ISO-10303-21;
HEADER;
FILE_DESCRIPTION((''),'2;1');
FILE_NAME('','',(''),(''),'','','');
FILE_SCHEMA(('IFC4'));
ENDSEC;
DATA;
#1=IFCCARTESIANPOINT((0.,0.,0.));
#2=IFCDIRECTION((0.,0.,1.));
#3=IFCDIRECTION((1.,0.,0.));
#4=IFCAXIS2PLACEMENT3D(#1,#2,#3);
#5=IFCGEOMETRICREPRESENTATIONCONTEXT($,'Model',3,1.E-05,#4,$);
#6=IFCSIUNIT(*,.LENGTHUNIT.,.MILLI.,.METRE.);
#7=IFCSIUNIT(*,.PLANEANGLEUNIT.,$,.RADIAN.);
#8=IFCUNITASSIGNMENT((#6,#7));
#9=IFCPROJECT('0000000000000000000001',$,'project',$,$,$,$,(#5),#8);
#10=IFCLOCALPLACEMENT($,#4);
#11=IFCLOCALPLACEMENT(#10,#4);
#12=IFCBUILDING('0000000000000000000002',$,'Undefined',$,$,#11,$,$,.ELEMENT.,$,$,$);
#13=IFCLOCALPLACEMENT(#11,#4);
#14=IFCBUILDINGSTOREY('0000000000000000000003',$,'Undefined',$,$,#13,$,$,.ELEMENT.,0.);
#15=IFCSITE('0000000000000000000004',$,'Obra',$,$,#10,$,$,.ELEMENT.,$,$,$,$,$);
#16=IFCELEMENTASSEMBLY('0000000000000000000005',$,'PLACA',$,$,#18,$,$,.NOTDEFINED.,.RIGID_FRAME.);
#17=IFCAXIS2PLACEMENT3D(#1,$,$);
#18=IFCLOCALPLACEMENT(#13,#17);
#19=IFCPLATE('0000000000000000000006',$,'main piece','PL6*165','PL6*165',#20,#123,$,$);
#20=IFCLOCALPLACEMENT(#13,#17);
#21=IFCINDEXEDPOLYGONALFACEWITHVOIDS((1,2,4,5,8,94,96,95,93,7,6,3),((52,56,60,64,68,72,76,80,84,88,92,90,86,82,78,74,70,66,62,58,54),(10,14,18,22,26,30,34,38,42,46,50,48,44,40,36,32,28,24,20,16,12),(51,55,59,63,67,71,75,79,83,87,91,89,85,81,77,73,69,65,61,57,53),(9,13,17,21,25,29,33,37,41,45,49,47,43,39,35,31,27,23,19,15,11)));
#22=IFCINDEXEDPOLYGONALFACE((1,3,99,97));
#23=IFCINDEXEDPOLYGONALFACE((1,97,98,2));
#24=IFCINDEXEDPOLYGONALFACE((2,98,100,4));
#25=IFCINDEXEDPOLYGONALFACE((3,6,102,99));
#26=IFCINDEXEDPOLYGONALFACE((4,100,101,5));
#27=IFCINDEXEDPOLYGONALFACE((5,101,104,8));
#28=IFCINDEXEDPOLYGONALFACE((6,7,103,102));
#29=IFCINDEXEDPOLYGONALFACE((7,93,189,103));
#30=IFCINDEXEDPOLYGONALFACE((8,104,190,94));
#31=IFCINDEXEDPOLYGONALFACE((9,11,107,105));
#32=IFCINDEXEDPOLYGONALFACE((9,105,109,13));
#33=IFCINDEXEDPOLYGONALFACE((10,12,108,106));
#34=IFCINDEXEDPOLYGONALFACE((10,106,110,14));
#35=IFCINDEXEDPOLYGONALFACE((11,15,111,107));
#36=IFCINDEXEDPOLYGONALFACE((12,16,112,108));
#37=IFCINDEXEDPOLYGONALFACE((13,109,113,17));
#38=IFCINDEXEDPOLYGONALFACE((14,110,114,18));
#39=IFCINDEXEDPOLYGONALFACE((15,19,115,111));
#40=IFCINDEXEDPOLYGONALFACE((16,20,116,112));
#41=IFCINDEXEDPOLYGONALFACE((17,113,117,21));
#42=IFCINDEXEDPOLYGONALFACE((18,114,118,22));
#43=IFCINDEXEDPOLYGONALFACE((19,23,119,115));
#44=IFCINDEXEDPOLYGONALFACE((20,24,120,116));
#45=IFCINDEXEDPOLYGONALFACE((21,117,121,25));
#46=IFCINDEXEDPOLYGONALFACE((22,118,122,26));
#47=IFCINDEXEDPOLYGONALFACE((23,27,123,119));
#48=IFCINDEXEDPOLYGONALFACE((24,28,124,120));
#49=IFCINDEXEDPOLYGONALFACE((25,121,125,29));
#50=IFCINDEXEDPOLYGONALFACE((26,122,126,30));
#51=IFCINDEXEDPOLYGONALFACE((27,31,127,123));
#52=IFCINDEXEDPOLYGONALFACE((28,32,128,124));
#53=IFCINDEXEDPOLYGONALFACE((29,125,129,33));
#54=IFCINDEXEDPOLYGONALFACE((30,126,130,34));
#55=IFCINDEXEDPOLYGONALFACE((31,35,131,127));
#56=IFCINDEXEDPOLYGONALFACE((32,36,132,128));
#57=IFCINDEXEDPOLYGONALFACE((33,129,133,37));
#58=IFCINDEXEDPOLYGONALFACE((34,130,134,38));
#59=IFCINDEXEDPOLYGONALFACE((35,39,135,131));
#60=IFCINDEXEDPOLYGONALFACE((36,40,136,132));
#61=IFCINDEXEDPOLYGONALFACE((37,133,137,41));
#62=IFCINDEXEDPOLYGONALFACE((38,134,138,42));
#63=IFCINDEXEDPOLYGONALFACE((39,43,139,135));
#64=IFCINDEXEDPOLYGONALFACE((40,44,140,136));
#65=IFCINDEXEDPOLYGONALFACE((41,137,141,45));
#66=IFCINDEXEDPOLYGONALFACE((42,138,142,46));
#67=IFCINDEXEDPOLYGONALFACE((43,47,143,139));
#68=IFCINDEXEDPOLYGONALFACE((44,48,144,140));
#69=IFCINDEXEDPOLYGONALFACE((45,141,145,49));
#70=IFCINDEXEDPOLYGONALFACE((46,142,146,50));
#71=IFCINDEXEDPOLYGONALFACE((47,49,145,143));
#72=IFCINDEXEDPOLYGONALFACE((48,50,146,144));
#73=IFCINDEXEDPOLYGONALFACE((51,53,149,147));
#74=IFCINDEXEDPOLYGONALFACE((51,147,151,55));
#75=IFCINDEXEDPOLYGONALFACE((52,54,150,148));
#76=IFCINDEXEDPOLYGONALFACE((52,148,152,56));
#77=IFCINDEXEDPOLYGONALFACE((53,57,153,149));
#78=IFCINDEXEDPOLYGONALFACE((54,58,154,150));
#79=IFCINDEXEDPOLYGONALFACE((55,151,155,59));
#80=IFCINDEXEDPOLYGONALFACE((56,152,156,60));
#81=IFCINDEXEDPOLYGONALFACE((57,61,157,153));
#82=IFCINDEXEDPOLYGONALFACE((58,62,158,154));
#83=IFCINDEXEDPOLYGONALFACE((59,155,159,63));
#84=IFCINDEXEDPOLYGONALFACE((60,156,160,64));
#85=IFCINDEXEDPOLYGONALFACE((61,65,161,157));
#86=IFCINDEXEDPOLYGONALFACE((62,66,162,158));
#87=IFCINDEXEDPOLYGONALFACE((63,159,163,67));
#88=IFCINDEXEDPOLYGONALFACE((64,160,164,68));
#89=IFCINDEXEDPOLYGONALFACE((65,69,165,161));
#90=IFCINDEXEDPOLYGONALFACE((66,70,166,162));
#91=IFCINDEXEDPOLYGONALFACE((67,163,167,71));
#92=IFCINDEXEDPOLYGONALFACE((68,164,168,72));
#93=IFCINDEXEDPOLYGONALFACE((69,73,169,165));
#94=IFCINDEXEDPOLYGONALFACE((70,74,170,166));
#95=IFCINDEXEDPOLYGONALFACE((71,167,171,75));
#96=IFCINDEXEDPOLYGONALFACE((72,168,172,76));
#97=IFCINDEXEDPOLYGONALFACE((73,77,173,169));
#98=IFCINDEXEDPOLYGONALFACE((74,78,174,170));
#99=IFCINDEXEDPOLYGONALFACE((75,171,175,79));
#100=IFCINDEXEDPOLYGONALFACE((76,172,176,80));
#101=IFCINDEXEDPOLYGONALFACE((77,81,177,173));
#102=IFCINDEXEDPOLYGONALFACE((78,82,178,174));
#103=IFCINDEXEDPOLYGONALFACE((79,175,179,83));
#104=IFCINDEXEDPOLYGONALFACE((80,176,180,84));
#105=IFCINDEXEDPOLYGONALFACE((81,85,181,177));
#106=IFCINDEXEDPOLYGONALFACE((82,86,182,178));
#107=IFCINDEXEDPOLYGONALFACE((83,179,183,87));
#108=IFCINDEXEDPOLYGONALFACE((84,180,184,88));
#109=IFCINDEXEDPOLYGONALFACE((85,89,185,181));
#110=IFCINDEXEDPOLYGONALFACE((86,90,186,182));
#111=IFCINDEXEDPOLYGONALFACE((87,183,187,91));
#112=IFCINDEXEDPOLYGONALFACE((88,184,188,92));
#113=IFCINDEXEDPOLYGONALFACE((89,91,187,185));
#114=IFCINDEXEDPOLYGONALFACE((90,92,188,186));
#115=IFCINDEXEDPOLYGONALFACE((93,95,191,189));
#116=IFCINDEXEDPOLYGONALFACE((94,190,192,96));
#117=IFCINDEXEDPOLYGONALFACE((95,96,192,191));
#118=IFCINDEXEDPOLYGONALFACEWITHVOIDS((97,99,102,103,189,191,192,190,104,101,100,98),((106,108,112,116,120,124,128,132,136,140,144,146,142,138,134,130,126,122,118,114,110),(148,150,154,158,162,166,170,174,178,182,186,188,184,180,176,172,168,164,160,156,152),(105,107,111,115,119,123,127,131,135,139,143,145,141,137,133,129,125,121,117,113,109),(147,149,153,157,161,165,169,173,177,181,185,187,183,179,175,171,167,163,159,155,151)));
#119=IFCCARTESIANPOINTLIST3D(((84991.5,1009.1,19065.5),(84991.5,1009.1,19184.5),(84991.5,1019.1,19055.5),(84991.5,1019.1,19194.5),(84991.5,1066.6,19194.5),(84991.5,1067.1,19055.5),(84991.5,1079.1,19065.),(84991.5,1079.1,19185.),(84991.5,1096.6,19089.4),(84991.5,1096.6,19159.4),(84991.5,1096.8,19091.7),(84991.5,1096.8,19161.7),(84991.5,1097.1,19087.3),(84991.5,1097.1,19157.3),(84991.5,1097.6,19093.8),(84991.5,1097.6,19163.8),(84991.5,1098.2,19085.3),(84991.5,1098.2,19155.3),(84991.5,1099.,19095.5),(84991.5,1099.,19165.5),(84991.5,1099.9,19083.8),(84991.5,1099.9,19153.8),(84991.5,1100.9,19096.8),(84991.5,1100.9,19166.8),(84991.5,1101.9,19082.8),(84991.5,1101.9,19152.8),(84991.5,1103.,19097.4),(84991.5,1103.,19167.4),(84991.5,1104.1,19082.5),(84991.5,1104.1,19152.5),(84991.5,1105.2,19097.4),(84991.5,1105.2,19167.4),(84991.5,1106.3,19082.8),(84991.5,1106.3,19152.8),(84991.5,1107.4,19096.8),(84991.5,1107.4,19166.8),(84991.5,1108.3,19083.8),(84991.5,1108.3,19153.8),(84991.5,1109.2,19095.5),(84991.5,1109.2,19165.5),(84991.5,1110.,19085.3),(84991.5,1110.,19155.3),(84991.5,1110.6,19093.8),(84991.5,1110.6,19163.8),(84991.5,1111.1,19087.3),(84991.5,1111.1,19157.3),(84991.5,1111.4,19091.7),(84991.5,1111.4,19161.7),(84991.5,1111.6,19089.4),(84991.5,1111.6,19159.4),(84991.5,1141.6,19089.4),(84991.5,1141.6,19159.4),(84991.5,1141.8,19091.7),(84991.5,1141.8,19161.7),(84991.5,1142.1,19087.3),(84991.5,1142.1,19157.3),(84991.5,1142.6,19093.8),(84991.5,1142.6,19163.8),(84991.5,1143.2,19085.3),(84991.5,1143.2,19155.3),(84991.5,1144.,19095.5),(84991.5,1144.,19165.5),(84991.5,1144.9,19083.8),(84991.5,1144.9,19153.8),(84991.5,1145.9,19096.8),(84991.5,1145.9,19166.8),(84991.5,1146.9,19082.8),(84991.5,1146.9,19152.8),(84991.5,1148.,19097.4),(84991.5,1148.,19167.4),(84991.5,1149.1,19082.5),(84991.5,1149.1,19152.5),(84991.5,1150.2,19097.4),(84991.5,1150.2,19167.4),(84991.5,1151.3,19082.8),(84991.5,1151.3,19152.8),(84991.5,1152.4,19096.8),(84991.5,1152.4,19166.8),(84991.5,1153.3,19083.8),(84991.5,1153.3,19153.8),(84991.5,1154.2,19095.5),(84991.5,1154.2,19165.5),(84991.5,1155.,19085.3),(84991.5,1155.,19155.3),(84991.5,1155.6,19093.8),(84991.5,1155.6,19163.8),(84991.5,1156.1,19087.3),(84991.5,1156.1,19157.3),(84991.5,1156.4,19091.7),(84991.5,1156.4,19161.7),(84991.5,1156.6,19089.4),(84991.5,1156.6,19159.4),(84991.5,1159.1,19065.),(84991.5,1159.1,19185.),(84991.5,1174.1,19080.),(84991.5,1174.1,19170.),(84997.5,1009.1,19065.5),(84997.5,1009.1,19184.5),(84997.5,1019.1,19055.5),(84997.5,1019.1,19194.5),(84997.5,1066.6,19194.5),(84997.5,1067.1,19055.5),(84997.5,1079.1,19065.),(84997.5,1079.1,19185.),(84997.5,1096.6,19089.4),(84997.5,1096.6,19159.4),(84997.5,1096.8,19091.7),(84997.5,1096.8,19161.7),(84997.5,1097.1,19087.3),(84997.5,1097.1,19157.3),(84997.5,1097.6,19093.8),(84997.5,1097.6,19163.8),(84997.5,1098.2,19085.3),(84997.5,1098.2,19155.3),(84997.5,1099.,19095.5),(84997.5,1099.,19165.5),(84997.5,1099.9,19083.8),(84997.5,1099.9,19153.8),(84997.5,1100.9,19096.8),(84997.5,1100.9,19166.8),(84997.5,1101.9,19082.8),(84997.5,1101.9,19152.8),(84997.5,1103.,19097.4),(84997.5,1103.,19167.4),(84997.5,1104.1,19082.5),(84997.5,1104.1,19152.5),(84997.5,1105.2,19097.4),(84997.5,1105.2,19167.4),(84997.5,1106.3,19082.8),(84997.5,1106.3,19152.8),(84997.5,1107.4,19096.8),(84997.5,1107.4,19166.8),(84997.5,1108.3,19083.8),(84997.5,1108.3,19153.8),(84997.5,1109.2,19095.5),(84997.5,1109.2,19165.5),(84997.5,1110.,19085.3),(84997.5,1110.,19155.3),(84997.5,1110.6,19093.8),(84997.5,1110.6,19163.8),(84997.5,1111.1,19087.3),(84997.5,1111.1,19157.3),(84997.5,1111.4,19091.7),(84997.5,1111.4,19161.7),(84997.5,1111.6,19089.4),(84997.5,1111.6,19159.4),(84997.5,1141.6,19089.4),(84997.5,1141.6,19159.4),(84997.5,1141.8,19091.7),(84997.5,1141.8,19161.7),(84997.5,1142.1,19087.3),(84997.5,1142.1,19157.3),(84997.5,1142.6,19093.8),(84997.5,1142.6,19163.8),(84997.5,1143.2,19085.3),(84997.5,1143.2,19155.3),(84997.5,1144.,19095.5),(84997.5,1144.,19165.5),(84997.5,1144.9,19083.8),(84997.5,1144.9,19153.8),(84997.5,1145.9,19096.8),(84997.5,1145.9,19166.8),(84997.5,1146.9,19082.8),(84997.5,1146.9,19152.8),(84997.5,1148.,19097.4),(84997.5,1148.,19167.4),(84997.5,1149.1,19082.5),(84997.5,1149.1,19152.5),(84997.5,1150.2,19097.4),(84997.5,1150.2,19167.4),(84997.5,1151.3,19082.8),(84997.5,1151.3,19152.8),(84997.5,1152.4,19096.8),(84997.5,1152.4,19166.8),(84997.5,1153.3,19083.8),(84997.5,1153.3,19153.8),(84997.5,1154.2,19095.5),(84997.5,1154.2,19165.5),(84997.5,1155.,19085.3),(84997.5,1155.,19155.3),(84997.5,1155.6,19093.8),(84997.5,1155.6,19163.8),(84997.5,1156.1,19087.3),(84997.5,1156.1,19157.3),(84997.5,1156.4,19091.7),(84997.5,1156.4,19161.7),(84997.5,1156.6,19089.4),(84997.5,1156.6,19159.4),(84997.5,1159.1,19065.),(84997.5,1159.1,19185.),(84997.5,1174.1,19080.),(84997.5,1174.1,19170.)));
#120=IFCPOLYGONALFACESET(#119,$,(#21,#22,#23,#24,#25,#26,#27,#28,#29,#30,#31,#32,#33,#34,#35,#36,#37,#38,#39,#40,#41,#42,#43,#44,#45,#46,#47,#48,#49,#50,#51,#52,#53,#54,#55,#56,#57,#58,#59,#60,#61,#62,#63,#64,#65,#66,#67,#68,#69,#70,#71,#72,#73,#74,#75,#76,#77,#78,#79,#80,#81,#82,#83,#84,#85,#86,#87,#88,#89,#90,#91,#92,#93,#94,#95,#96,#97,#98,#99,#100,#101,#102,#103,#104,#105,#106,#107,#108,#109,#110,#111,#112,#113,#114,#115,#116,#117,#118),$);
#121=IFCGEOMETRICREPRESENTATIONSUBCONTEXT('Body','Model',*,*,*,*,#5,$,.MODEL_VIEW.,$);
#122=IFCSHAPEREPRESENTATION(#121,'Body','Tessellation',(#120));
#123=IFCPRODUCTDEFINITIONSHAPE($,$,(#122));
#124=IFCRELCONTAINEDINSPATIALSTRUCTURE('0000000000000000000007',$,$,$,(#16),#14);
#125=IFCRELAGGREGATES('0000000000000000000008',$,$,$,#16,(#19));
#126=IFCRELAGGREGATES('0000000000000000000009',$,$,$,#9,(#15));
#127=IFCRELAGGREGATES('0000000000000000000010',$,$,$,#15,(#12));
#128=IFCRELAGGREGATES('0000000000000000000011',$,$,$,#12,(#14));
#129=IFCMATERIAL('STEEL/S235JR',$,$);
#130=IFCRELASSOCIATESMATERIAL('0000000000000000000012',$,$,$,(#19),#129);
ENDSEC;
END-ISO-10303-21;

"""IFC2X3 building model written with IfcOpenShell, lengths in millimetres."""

from ifc_helpers import new_model, si_unit, frame, origin_with_axes, origin_2d_with_axis, place, context, subcontext, project, spatial, polyline, circle, outline, extrude, source, transform, mapped, material, element, aggregate, save


model = new_model("IFC2X3")

# Units and contexts
model_context = context("Model", 3, precision=1e-05, world=origin_with_axes())
body_context = subcontext(model_context, "Body", "Model", "MODEL_VIEW")
ifc_project = project(units=[si_unit("LENGTHUNIT", "METRE", prefix="MILLI"), si_unit("PLANEANGLEUNIT", "RADIAN")], contexts=[model_context])

# Site, building, storey
site_placement = place(None, origin_with_axes())
site = spatial("IfcSite", under=ifc_project, at=site_placement, Name="Obra", CompositionType="ELEMENT")
building_placement = place(site_placement, origin_with_axes())
building = spatial("IfcBuilding", under=site, at=building_placement, Name="Undefined", CompositionType="ELEMENT")
storey_placement = place(building_placement, origin_with_axes())
storey = spatial("IfcBuildingStorey", under=building, at=storey_placement, Name="Undefined", CompositionType="ELEMENT", Elevation=0.0)

# Shared definitions
ifc_material_1 = material(Name="STEEL/S235JR")

# Element assembly, plate, opening
assembly_1_placement = place(storey_placement, origin_with_axes())
assembly_1 = element("IfcElementAssembly", 1, at=assembly_1_placement, inside=storey, Name="PLACA", AssemblyPlace="NOTDEFINED", PredefinedType="RIGID_FRAME")
plate_1_placement = place(assembly_1_placement, frame((84994.5, 1009.1, 19065.5), z_axis=(1.0, 0.0, 0.0), x_axis=(0.0, 0.707107, -0.707107)))
plate_1 = element("IfcPlate", 2, at=plate_1_placement, material=ifc_material_1, Name="main piece", Description="PL6*165", ObjectType="PL6*165", context=body_context, shape_type="SweptSolid", body=[
    extrude(outline(polyline([(0.0, 0.0), (14.1, 0.0), (48.1, 33.9), (49.9, 49.1), (106.4, 105.7), (106.4, 126.9), (42.8, 190.6), (21.6, 190.6), (-35.0, 134.0), (-50.6, 131.9), (-84.1, 98.3), (-84.1, 84.1), (0.0, 0.0)])), frame((0.0, 0.0, -3.0), z_axis=(0.0, 0.0, 1.0), x_axis=(1.0, 0.0, 0.0)), (0.0, 0.0, 1.0), 6.0),
])
shared_shape_1 = source(origin_with_axes(), body_context, "Body", "SweptSolid", [
    extrude(circle(Radius=7.5, at=origin_2d_with_axis()), frame((0.0, 2.4, 0.0), z_axis=(0.0, 1.0, 0.0), x_axis=(1.0, 0.0, 0.0)), (0.0, 0.0, 1.0), 6.2),
])
opening_1_placement = place(assembly_1_placement, frame((85000.0, 1126.6, 19160.0), z_axis=(0.0, 1.0, 0.0), x_axis=(0.0, 0.0, -1.0)))
element("IfcOpeningElement", 3, at=opening_1_placement, cuts=plate_1, ObjectType="Opening", context=body_context, shape_type="MappedRepresentation", body=[
    mapped(shared_shape_1, transform((0.0, 0.0, -22.5))),
    mapped(shared_shape_1, transform((70.0, 0.0, -22.5))),
    mapped(shared_shape_1, transform((0.0, 0.0, 22.5))),
    mapped(shared_shape_1, transform((70.0, 0.0, 22.5))),
])
aggregate(assembly_1, [plate_1])

save(model, "model.ifc")
